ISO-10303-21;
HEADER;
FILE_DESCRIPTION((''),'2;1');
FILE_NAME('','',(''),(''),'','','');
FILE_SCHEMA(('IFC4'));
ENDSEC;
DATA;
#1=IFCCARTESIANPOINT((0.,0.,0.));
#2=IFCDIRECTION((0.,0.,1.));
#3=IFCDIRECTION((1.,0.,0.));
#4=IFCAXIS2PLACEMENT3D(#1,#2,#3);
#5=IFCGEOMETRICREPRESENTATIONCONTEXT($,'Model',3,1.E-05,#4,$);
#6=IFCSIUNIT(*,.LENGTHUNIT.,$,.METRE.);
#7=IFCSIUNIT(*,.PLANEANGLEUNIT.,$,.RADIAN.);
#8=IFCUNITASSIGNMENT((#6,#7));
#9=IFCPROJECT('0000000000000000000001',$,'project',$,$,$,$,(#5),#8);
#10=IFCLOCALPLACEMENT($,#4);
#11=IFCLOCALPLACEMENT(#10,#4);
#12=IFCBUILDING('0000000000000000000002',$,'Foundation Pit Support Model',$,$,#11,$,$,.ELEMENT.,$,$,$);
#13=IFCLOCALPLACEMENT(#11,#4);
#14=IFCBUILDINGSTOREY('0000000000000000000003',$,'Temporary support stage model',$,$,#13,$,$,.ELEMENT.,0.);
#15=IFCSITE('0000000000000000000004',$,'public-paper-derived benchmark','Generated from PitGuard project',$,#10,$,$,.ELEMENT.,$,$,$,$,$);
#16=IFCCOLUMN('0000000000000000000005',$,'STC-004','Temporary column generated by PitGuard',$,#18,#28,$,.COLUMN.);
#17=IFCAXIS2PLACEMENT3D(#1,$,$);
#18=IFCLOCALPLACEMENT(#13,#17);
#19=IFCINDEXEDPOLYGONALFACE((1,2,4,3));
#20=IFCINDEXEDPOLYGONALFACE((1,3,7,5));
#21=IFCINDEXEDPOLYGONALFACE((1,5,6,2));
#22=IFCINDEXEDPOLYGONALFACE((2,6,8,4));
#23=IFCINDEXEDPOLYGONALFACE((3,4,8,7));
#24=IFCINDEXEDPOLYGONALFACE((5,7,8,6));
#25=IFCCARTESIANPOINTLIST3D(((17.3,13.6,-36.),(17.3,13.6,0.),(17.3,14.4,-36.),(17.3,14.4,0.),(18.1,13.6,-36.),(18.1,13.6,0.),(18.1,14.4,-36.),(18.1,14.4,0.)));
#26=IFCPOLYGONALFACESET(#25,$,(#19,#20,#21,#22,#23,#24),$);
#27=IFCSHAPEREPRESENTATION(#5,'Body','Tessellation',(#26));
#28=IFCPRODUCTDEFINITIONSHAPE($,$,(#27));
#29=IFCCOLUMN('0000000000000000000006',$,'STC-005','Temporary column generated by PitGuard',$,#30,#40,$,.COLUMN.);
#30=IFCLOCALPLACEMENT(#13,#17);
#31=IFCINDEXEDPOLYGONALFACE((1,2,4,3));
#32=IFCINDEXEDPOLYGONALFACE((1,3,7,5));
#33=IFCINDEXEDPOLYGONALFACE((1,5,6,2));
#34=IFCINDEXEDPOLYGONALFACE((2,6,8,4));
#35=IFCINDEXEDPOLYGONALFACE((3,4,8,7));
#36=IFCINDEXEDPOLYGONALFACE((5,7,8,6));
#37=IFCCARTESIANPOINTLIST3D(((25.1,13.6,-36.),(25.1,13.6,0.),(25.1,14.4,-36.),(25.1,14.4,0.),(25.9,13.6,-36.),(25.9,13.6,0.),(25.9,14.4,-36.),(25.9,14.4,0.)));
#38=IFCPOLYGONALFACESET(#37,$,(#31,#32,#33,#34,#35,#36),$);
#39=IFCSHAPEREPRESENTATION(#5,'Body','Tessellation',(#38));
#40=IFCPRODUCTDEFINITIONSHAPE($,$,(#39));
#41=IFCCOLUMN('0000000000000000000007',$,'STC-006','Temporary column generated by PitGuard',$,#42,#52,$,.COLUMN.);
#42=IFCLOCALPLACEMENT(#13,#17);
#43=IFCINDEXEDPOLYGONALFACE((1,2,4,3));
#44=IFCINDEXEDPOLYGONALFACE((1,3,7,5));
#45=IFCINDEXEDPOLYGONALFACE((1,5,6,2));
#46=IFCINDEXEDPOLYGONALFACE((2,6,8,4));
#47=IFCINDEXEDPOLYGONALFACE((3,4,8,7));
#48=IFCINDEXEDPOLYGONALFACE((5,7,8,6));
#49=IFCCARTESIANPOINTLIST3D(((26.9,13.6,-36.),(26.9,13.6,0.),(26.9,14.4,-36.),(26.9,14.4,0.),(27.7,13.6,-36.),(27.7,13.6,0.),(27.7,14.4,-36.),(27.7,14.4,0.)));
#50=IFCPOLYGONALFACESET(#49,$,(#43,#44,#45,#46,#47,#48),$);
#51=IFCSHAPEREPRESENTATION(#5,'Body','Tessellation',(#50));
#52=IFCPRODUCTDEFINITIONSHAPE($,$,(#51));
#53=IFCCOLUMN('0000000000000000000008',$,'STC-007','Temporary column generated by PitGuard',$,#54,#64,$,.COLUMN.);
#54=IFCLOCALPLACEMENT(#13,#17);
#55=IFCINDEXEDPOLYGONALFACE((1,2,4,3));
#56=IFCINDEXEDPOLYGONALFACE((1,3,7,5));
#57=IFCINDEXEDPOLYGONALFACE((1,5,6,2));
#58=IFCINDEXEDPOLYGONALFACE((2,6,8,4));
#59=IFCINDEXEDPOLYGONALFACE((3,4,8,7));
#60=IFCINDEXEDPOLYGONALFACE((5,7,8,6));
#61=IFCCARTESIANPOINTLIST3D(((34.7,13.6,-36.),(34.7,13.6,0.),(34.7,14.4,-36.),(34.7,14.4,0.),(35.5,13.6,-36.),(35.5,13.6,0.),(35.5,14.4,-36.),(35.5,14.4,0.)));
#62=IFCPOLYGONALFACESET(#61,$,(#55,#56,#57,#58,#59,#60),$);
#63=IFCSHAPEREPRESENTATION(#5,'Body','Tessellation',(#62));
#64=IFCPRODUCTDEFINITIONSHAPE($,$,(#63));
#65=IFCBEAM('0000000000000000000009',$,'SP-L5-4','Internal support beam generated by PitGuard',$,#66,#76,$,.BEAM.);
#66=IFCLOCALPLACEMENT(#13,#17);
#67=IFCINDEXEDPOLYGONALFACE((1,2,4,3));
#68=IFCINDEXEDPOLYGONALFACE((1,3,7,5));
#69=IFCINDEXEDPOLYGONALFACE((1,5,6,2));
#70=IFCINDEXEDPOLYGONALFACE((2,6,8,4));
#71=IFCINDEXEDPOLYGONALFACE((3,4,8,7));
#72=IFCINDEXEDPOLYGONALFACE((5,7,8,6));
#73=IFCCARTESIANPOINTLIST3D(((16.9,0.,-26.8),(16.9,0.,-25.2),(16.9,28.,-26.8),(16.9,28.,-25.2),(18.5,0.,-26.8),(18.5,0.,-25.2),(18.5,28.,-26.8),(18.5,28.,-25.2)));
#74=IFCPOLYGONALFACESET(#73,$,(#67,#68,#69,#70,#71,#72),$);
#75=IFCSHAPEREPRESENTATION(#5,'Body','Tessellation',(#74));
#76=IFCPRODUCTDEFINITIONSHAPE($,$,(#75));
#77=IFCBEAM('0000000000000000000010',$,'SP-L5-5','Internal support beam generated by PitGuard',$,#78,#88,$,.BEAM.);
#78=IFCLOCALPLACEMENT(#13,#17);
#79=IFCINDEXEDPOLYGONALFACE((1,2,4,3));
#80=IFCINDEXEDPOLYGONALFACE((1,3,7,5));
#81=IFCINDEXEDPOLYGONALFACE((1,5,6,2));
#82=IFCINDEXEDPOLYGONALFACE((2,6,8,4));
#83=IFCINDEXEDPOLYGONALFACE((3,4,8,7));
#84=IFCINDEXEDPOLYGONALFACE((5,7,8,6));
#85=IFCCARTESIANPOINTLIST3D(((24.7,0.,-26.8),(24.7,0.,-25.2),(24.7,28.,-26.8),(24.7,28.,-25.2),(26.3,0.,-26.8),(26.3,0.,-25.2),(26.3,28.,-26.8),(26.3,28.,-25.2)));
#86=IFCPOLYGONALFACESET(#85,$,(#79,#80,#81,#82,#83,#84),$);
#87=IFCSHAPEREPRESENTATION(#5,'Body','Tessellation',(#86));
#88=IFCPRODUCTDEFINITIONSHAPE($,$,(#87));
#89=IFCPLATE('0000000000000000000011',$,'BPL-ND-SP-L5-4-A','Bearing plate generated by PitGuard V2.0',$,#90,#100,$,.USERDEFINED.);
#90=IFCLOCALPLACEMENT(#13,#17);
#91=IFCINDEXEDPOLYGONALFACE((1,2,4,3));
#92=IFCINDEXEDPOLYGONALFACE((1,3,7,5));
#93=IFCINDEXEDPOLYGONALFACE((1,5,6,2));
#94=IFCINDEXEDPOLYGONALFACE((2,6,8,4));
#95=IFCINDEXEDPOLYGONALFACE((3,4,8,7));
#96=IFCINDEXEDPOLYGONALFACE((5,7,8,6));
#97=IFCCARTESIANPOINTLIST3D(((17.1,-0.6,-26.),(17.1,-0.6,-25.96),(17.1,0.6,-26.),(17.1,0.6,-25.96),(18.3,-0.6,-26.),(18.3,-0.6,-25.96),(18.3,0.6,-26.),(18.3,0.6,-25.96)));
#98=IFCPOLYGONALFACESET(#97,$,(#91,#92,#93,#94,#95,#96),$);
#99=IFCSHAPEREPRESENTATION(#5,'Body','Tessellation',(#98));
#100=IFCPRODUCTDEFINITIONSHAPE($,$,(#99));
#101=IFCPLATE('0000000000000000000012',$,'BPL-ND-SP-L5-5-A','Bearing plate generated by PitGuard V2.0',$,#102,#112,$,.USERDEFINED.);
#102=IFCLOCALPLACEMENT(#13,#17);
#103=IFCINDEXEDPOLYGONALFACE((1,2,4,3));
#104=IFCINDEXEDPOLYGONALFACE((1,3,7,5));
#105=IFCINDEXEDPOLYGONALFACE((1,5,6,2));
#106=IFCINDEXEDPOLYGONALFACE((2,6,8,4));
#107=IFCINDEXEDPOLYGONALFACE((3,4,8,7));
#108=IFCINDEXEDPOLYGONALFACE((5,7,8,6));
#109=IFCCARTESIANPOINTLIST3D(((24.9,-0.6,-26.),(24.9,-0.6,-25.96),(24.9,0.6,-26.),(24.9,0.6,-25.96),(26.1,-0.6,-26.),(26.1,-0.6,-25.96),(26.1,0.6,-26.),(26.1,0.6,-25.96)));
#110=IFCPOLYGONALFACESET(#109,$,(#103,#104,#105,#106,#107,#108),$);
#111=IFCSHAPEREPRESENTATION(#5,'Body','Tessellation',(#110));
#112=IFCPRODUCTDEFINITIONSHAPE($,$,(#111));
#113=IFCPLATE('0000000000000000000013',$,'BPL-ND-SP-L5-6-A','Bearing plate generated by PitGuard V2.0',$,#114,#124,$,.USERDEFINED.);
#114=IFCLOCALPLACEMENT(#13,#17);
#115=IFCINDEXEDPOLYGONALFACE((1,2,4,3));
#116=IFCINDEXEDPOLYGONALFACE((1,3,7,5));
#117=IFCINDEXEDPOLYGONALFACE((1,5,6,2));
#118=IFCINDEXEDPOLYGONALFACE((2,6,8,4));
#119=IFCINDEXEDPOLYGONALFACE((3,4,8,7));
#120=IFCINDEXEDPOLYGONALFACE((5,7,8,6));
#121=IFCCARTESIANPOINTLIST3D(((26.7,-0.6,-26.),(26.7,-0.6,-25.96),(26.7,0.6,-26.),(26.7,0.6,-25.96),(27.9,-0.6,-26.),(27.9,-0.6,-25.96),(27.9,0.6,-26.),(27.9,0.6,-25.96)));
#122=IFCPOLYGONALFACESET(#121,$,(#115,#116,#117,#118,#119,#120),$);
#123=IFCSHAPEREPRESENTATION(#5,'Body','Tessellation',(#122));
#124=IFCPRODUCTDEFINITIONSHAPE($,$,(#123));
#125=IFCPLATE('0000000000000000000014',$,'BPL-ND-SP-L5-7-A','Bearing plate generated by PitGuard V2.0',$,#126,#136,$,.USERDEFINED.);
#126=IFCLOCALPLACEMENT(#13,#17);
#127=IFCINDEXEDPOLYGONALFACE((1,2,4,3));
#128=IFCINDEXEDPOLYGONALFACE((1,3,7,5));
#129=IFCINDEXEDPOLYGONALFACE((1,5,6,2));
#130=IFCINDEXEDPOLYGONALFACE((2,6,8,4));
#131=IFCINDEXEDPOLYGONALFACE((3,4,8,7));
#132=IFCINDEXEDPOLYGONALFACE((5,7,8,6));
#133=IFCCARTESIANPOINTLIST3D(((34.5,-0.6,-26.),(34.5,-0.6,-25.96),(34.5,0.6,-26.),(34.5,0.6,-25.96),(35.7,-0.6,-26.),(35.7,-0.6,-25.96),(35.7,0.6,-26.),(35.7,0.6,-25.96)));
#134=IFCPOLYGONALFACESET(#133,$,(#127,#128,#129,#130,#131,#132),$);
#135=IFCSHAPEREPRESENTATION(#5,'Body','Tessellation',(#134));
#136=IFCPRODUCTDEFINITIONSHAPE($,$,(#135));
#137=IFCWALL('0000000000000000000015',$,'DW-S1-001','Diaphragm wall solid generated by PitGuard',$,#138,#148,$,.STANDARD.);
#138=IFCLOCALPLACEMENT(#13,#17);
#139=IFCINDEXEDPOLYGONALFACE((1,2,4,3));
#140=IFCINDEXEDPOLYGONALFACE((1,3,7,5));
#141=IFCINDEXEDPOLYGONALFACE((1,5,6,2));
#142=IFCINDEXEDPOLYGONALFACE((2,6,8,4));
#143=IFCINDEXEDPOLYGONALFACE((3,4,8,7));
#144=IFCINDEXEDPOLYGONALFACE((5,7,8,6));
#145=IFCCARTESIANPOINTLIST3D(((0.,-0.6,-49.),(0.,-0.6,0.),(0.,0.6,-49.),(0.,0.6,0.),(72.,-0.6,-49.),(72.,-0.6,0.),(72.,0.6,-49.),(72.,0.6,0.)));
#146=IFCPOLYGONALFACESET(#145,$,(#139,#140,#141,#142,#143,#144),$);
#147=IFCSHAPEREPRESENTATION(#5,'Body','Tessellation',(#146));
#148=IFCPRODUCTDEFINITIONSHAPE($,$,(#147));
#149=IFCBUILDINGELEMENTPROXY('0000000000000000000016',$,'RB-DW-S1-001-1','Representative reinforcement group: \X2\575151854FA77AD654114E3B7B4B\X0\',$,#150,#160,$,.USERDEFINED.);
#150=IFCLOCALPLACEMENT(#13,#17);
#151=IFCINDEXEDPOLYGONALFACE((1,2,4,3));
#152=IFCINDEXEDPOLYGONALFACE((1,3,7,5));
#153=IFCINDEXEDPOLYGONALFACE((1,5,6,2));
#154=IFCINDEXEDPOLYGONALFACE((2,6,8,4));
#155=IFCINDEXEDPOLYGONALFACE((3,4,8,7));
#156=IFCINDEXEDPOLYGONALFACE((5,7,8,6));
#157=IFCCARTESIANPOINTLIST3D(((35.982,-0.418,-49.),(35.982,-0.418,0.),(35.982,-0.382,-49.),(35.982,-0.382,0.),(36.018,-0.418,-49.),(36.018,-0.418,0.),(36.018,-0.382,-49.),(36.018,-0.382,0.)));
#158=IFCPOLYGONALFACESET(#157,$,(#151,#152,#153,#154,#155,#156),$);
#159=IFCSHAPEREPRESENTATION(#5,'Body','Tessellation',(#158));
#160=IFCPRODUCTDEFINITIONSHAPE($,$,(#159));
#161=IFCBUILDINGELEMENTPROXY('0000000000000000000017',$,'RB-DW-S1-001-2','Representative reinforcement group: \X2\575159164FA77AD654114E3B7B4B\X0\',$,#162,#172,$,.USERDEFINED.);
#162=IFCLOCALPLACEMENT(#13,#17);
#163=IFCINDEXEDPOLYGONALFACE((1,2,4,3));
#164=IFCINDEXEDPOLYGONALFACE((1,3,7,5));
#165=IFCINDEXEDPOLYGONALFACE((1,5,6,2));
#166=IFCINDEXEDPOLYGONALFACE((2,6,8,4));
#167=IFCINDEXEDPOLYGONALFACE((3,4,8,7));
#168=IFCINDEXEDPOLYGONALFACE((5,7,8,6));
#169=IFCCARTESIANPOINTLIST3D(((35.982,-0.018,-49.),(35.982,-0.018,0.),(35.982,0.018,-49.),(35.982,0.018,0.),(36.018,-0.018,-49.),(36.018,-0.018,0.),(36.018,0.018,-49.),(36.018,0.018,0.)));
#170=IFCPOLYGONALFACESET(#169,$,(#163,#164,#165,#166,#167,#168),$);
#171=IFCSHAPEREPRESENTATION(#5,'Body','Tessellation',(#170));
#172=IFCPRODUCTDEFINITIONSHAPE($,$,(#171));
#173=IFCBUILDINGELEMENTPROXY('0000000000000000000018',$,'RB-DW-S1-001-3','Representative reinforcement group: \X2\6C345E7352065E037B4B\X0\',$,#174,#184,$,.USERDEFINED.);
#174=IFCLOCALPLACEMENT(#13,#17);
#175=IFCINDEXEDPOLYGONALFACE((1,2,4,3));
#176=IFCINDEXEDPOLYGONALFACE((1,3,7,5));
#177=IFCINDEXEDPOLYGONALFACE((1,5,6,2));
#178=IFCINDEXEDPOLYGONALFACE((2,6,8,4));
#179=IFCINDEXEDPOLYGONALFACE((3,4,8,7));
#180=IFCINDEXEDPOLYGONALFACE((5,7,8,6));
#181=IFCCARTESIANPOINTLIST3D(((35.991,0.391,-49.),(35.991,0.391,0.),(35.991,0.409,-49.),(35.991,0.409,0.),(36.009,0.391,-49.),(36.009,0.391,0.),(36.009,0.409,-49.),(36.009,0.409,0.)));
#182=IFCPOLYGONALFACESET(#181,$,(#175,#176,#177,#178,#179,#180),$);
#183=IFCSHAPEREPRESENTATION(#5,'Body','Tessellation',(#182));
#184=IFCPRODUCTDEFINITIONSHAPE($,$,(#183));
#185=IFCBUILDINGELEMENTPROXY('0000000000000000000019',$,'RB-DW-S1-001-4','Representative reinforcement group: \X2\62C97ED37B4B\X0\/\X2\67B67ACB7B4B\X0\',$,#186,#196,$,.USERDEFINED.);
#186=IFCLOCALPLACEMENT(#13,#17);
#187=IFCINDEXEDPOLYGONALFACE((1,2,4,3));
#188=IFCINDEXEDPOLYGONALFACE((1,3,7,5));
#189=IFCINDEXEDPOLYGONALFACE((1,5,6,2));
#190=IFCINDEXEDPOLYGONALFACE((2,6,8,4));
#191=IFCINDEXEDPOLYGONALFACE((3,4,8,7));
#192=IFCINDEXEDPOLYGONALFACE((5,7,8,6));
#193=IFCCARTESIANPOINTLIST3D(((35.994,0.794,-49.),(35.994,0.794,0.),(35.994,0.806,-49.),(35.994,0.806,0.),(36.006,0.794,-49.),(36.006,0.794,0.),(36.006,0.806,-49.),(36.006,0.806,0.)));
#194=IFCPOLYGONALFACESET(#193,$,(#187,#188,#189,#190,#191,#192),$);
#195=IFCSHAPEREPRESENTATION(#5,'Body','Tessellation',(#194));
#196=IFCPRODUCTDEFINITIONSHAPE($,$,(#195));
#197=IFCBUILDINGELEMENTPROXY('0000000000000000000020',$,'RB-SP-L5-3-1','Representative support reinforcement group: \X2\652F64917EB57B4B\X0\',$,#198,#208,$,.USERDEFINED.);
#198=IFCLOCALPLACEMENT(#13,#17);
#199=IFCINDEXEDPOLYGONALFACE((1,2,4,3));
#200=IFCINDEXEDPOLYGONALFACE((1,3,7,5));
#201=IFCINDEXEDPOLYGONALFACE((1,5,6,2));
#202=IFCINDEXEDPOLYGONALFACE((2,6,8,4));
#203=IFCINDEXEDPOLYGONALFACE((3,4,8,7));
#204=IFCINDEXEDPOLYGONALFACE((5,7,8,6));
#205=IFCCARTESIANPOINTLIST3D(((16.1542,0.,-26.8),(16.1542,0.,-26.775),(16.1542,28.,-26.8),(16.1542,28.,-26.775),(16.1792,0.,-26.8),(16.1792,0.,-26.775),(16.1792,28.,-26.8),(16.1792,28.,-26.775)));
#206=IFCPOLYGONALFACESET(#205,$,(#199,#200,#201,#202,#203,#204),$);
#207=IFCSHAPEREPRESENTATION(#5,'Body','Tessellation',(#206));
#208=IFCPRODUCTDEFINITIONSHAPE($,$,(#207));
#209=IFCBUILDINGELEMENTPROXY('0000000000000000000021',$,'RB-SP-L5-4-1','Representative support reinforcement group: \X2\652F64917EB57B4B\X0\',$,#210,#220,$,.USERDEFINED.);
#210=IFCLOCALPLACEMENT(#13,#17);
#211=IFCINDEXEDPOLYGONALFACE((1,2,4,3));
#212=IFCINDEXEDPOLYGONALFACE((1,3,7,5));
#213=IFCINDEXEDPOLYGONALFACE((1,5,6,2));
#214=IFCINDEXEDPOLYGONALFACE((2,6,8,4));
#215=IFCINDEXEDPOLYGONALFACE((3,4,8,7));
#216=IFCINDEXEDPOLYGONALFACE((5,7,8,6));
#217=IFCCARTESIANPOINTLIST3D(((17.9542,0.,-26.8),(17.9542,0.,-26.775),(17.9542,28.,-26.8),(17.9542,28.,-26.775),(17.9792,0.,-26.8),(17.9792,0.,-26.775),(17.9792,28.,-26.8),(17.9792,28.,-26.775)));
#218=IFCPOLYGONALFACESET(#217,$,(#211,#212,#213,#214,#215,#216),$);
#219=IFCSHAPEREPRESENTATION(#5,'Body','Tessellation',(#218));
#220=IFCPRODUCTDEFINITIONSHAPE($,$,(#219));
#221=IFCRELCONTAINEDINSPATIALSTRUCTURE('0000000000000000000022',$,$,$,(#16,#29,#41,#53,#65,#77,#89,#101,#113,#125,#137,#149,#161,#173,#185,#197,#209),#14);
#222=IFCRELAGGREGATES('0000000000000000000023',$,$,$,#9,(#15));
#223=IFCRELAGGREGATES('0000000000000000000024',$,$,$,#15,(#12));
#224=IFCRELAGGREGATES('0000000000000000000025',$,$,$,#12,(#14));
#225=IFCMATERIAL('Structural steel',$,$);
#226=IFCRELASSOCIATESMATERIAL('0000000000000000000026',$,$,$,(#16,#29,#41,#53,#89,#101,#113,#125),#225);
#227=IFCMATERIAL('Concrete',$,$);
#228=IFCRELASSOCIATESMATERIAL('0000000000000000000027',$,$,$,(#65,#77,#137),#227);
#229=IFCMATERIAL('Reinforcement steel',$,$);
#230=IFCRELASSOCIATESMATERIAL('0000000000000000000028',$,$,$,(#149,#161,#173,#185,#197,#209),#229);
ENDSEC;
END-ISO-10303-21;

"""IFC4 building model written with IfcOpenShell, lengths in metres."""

from ifc_helpers import new_model, si_unit, frame, origin_with_axes, origin_2d, place, context, project, spatial, rectangle, extrude, material, element, save


model = new_model("IFC4")

# Units and contexts
model_context = context("Model", 3, precision=1e-05, world=origin_with_axes())
ifc_project = project(units=[si_unit("LENGTHUNIT", "METRE"), si_unit("PLANEANGLEUNIT", "RADIAN")], contexts=[model_context])

# Site, building, storey
site_placement = place(None, origin_with_axes())
site = spatial("IfcSite", under=ifc_project, at=site_placement, Name="public-paper-derived benchmark", Description="Generated from PitGuard project", CompositionType="ELEMENT")
building_placement = place(site_placement, origin_with_axes())
building = spatial("IfcBuilding", under=site, at=building_placement, Name="Foundation Pit Support Model", CompositionType="ELEMENT")
storey_placement = place(building_placement, origin_with_axes())
storey = spatial("IfcBuildingStorey", under=building, at=storey_placement, Name="Temporary support stage model", CompositionType="ELEMENT", Elevation=0.0)

# Columns
ifc_material_1 = material(Name="Structural steel")
for number, where, z_axis, x_axis, name in (
    (1, (17.7, 14.0, -36.0), (0.0, 0.0, 1.0), (1.0, 0.0, 0.0), "STC-004"),
    (2, (25.5, 14.0, -36.0), (0.0, 0.0, 1.0), (1.0, 0.0, 0.0), "STC-005"),
    (3, (27.3, 14.0, -36.0), (0.0, 0.0, 1.0), (1.0, 0.0, 0.0), "STC-006"),
    (4, (35.1, 14.0, -36.0), (0.0, 0.0, 1.0), (1.0, 0.0, 0.0), "STC-007"),
):
    element("IfcColumn", number, at=place(storey_placement, frame(where, z_axis=z_axis, x_axis=x_axis)), inside=storey, material=ifc_material_1, Name=name, Description="Temporary column generated by PitGuard", PredefinedType="COLUMN", context=model_context, shape_type="SweptSolid", body=[
        extrude(rectangle(XDim=0.8, YDim=0.8, at=origin_2d()), origin_with_axes(), (0.0, 0.0, 1.0), 36.0),
    ])

# Beams
ifc_material_2 = material(Name="Concrete")
for number, where, z_axis, x_axis, name in (
    (5, (17.7, 14.0, -26.8), (0.0, 0.0, 1.0), (0.0, 1.0, 0.0), "SP-L5-4"),
    (6, (25.5, 14.0, -26.8), (0.0, 0.0, 1.0), (0.0, 1.0, 0.0), "SP-L5-5"),
):
    element("IfcBeam", number, at=place(storey_placement, frame(where, z_axis=z_axis, x_axis=x_axis)), inside=storey, material=ifc_material_2, Name=name, Description="Internal support beam generated by PitGuard", PredefinedType="BEAM", context=model_context, shape_type="SweptSolid", body=[
        extrude(rectangle(XDim=28.0, YDim=1.6, at=origin_2d()), origin_with_axes(), (0.0, 0.0, 1.0), 1.6),
    ])

# Plates
for number, where, z_axis, x_axis, name in (
    (7, (17.7, 0.0, -26.0), (0.0, 0.0, 1.0), (1.0, 0.0, 0.0), "BPL-ND-SP-L5-4-A"),
    (8, (25.5, 0.0, -26.0), (0.0, 0.0, 1.0), (1.0, 0.0, 0.0), "BPL-ND-SP-L5-5-A"),
    (9, (27.3, 0.0, -26.0), (0.0, 0.0, 1.0), (1.0, 0.0, 0.0), "BPL-ND-SP-L5-6-A"),
    (10, (35.1, 0.0, -26.0), (0.0, 0.0, 1.0), (1.0, 0.0, 0.0), "BPL-ND-SP-L5-7-A"),
):
    element("IfcPlate", number, at=place(storey_placement, frame(where, z_axis=z_axis, x_axis=x_axis)), inside=storey, material=ifc_material_1, Name=name, Description="Bearing plate generated by PitGuard V2.0", PredefinedType="USERDEFINED", context=model_context, shape_type="SweptSolid", body=[
        extrude(rectangle(XDim=1.2, YDim=1.2, at=origin_2d()), origin_with_axes(), (0.0, 0.0, 1.0), 0.04),
    ])

# Wall
wall_placement = place(storey_placement, frame((36.0, 0.0, -49.0), z_axis=(0.0, 0.0, 1.0), x_axis=(1.0, 0.0, 0.0)))
element("IfcWall", 11, at=wall_placement, inside=storey, material=ifc_material_2, Name="DW-S1-001", Description="Diaphragm wall solid generated by PitGuard", PredefinedType="STANDARD", context=model_context, shape_type="SweptSolid", body=[
    extrude(rectangle(XDim=72.0, YDim=1.2, at=origin_2d()), origin_with_axes(), (0.0, 0.0, 1.0), 49.0),
])

# Building element proxies
ifc_material_3 = material(Name="Reinforcement steel")
for number, where, z_axis, x_axis, name, description in (
    (12, (36.0, -0.4, -49.0), (0.0, 0.0, 1.0), (1.0, 0.0, 0.0), "RB-DW-S1-001-1", "Representative reinforcement group: 坑内侧竖向主筋"),
    (13, (36.0, 0.0, -49.0), (0.0, 0.0, 1.0), (1.0, 0.0, 0.0), "RB-DW-S1-001-2", "Representative reinforcement group: 坑外侧竖向主筋"),
):
    element("IfcBuildingElementProxy", number, at=place(storey_placement, frame(where, z_axis=z_axis, x_axis=x_axis)), inside=storey, material=ifc_material_3, Name=name, Description=description, PredefinedType="USERDEFINED", context=model_context, shape_type="SweptSolid", body=[
        extrude(rectangle(XDim=0.036, YDim=0.036, at=origin_2d()), origin_with_axes(), (0.0, 0.0, 1.0), 49.0),
    ])
proxy_1_placement = place(storey_placement, frame((36.0, 0.4, -49.0), z_axis=(0.0, 0.0, 1.0), x_axis=(1.0, 0.0, 0.0)))
element("IfcBuildingElementProxy", 14, at=proxy_1_placement, inside=storey, material=ifc_material_3, Name="RB-DW-S1-001-3", Description="Representative reinforcement group: 水平分布筋", PredefinedType="USERDEFINED", context=model_context, shape_type="SweptSolid", body=[
    extrude(rectangle(XDim=0.018, YDim=0.018, at=origin_2d()), origin_with_axes(), (0.0, 0.0, 1.0), 49.0),
])
proxy_2_placement = place(storey_placement, frame((36.0, 0.8, -49.0), z_axis=(0.0, 0.0, 1.0), x_axis=(1.0, 0.0, 0.0)))
element("IfcBuildingElementProxy", 15, at=proxy_2_placement, inside=storey, material=ifc_material_3, Name="RB-DW-S1-001-4", Description="Representative reinforcement group: 拉结筋/架立筋", PredefinedType="USERDEFINED", context=model_context, shape_type="SweptSolid", body=[
    extrude(rectangle(XDim=0.012, YDim=0.012, at=origin_2d()), origin_with_axes(), (0.0, 0.0, 1.0), 49.0),
])
for number, where, z_axis, x_axis, name in (
    (16, (16.1667, 14.0, -26.8), (0.0, 0.0, 1.0), (0.0, 1.0, 0.0), "RB-SP-L5-3-1"),
    (17, (17.9667, 14.0, -26.8), (0.0, 0.0, 1.0), (0.0, 1.0, 0.0), "RB-SP-L5-4-1"),
):
    element("IfcBuildingElementProxy", number, at=place(storey_placement, frame(where, z_axis=z_axis, x_axis=x_axis)), inside=storey, material=ifc_material_3, Name=name, Description="Representative support reinforcement group: 支撑纵筋", PredefinedType="USERDEFINED", context=model_context, shape_type="SweptSolid", body=[
        extrude(rectangle(XDim=28.0, YDim=0.025, at=origin_2d()), origin_with_axes(), (0.0, 0.0, 1.0), 0.025),
    ])

save(model, "model.ifc")
